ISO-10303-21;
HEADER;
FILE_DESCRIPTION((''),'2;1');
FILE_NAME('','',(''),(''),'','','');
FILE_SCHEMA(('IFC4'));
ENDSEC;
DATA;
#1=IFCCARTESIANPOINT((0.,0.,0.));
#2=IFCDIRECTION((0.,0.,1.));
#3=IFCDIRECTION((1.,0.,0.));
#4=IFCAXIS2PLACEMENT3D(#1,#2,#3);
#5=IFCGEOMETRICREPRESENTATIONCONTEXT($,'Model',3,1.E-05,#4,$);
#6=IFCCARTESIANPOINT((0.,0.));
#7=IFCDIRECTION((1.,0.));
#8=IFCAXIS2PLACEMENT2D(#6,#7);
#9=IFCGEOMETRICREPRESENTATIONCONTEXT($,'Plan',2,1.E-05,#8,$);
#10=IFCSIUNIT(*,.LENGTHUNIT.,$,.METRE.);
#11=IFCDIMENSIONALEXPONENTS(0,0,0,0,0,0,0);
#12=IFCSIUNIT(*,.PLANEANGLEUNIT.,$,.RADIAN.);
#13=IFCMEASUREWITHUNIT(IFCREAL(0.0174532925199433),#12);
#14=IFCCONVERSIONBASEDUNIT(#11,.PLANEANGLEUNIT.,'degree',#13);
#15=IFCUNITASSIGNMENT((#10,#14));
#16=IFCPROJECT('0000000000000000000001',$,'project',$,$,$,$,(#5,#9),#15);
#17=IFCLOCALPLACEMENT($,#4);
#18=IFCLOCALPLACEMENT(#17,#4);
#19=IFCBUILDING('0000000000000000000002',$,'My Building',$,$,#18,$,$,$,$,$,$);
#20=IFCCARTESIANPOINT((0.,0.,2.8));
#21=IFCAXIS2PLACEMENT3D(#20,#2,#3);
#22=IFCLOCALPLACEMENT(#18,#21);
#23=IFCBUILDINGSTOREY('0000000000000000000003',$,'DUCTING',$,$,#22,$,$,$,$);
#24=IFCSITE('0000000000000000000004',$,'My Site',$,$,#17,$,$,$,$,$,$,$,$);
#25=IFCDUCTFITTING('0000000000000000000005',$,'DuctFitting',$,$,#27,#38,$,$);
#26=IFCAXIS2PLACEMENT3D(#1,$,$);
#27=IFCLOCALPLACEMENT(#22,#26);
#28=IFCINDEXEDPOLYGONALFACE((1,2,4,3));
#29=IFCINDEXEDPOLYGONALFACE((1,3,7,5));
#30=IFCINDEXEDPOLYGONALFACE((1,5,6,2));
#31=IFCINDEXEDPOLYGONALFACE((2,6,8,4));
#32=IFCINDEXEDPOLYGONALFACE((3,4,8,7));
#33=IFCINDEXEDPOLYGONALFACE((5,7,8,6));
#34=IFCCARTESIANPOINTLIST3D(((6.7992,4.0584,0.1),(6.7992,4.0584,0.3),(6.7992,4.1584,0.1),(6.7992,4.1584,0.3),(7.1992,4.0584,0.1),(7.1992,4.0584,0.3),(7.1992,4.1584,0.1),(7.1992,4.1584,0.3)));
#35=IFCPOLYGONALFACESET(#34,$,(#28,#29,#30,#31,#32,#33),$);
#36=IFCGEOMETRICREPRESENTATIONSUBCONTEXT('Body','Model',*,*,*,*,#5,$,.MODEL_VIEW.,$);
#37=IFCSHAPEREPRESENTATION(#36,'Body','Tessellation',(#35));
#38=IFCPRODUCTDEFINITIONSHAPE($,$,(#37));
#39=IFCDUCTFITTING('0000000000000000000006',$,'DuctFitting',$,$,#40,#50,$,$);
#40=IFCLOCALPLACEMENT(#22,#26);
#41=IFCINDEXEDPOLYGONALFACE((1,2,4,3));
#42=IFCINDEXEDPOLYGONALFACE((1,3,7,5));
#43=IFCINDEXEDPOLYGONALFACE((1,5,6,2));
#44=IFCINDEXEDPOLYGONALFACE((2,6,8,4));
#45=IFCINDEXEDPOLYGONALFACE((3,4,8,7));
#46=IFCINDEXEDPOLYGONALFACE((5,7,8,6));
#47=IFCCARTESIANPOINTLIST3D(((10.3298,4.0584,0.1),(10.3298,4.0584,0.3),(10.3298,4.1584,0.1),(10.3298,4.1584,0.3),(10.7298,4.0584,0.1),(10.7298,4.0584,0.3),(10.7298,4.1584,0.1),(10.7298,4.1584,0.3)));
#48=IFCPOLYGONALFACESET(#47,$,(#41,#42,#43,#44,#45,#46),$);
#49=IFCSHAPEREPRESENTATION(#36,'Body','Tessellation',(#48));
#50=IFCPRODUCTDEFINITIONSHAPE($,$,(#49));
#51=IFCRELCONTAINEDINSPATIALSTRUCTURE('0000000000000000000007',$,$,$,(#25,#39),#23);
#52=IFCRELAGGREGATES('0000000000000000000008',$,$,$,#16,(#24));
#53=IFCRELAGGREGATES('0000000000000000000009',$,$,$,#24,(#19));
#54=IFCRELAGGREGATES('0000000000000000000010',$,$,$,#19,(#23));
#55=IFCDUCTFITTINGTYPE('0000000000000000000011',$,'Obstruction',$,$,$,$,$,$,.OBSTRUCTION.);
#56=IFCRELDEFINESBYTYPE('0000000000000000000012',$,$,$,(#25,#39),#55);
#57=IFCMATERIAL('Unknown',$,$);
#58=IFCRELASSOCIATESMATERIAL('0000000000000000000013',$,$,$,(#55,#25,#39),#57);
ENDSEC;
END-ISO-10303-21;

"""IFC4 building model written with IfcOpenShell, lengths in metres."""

from ifc_helpers import new_model, entity, si_unit, converted_unit, frame, origin_with_axes, origin_2d_with_axis, place, context, subcontext, project, spatial, rectangle, extrude, material, material_profile, profile_set, profile_usage, type_object, element, save


model = new_model("IFC4")

# Units and contexts
model_context = context("Model", 3, precision=1e-05, world=origin_with_axes())
plan_context = context("Plan", 2, precision=1e-05, world=origin_2d_with_axis())
body_context = subcontext(model_context, "Body", "Model", "MODEL_VIEW")
ifc_project = project(units=[si_unit("LENGTHUNIT", "METRE"), converted_unit("PLANEANGLEUNIT", "degree", entity("IfcReal", 0.0174532925199433), si_unit("PLANEANGLEUNIT", "RADIAN"), dimensions=[0, 0, 0, 0, 0, 0, 0])], contexts=[model_context, plan_context])

# Site, building, storey
site_placement = place(None, origin_with_axes())
site = spatial("IfcSite", under=ifc_project, at=site_placement, Name="My Site")
building_placement = place(site_placement, origin_with_axes())
building = spatial("IfcBuilding", under=site, at=building_placement, Name="My Building")
storey_placement = place(building_placement, frame((0.0, 0.0, 2.8), z_axis=(0.0, 0.0, 1.0), x_axis=(1.0, 0.0, 0.0)))
storey = spatial("IfcBuildingStorey", under=building, at=storey_placement, Name="DUCTING")

# Shared definitions
ifc_material = material(Name="Unknown")

# Duct fittings
ifc_material_profile_1 = material_profile(ifc_material, rectangle(XDim=0.4, YDim=0.2))
ifc_profile_set_1 = profile_set([ifc_material_profile_1])
duct_fitting_type_1 = type_object("IfcDuctFittingType", Name="Obstruction", PredefinedType="OBSTRUCTION", material=ifc_profile_set_1)
ifc_profile_usage_1 = profile_usage(ifc_profile_set_1, cardinal=5)
duct_fitting_1_placement = place(storey_placement, frame((6.9992, 4.1584, 0.2), z_axis=(-0.000025, -1.0, 0.0), x_axis=(1.0, -0.000025, 0.0)))
element("IfcDuctFitting", 1, at=duct_fitting_1_placement, inside=storey, type_object=duct_fitting_type_1, material=ifc_profile_usage_1, Name="DuctFitting", context=body_context, shape_type="SweptSolid", body=[
    extrude(rectangle(XDim=0.4, YDim=0.2), origin_with_axes(), (0.0, 0.0, 1.0), 0.1),
])
ifc_profile_usage_2 = profile_usage(ifc_profile_set_1, cardinal=5)
duct_fitting_2_placement = place(storey_placement, frame((10.5298, 4.1584, 0.2), z_axis=(-0.000025, -1.0, 0.0), x_axis=(1.0, -0.000025, 0.0)))
element("IfcDuctFitting", 2, at=duct_fitting_2_placement, inside=storey, type_object=duct_fitting_type_1, material=ifc_profile_usage_2, Name="DuctFitting", context=body_context, shape_type="SweptSolid", body=[
    extrude(rectangle(XDim=0.4, YDim=0.2), origin_with_axes(), (0.0, 0.0, 1.0), 0.1),
])

save(model, "model.ifc")
